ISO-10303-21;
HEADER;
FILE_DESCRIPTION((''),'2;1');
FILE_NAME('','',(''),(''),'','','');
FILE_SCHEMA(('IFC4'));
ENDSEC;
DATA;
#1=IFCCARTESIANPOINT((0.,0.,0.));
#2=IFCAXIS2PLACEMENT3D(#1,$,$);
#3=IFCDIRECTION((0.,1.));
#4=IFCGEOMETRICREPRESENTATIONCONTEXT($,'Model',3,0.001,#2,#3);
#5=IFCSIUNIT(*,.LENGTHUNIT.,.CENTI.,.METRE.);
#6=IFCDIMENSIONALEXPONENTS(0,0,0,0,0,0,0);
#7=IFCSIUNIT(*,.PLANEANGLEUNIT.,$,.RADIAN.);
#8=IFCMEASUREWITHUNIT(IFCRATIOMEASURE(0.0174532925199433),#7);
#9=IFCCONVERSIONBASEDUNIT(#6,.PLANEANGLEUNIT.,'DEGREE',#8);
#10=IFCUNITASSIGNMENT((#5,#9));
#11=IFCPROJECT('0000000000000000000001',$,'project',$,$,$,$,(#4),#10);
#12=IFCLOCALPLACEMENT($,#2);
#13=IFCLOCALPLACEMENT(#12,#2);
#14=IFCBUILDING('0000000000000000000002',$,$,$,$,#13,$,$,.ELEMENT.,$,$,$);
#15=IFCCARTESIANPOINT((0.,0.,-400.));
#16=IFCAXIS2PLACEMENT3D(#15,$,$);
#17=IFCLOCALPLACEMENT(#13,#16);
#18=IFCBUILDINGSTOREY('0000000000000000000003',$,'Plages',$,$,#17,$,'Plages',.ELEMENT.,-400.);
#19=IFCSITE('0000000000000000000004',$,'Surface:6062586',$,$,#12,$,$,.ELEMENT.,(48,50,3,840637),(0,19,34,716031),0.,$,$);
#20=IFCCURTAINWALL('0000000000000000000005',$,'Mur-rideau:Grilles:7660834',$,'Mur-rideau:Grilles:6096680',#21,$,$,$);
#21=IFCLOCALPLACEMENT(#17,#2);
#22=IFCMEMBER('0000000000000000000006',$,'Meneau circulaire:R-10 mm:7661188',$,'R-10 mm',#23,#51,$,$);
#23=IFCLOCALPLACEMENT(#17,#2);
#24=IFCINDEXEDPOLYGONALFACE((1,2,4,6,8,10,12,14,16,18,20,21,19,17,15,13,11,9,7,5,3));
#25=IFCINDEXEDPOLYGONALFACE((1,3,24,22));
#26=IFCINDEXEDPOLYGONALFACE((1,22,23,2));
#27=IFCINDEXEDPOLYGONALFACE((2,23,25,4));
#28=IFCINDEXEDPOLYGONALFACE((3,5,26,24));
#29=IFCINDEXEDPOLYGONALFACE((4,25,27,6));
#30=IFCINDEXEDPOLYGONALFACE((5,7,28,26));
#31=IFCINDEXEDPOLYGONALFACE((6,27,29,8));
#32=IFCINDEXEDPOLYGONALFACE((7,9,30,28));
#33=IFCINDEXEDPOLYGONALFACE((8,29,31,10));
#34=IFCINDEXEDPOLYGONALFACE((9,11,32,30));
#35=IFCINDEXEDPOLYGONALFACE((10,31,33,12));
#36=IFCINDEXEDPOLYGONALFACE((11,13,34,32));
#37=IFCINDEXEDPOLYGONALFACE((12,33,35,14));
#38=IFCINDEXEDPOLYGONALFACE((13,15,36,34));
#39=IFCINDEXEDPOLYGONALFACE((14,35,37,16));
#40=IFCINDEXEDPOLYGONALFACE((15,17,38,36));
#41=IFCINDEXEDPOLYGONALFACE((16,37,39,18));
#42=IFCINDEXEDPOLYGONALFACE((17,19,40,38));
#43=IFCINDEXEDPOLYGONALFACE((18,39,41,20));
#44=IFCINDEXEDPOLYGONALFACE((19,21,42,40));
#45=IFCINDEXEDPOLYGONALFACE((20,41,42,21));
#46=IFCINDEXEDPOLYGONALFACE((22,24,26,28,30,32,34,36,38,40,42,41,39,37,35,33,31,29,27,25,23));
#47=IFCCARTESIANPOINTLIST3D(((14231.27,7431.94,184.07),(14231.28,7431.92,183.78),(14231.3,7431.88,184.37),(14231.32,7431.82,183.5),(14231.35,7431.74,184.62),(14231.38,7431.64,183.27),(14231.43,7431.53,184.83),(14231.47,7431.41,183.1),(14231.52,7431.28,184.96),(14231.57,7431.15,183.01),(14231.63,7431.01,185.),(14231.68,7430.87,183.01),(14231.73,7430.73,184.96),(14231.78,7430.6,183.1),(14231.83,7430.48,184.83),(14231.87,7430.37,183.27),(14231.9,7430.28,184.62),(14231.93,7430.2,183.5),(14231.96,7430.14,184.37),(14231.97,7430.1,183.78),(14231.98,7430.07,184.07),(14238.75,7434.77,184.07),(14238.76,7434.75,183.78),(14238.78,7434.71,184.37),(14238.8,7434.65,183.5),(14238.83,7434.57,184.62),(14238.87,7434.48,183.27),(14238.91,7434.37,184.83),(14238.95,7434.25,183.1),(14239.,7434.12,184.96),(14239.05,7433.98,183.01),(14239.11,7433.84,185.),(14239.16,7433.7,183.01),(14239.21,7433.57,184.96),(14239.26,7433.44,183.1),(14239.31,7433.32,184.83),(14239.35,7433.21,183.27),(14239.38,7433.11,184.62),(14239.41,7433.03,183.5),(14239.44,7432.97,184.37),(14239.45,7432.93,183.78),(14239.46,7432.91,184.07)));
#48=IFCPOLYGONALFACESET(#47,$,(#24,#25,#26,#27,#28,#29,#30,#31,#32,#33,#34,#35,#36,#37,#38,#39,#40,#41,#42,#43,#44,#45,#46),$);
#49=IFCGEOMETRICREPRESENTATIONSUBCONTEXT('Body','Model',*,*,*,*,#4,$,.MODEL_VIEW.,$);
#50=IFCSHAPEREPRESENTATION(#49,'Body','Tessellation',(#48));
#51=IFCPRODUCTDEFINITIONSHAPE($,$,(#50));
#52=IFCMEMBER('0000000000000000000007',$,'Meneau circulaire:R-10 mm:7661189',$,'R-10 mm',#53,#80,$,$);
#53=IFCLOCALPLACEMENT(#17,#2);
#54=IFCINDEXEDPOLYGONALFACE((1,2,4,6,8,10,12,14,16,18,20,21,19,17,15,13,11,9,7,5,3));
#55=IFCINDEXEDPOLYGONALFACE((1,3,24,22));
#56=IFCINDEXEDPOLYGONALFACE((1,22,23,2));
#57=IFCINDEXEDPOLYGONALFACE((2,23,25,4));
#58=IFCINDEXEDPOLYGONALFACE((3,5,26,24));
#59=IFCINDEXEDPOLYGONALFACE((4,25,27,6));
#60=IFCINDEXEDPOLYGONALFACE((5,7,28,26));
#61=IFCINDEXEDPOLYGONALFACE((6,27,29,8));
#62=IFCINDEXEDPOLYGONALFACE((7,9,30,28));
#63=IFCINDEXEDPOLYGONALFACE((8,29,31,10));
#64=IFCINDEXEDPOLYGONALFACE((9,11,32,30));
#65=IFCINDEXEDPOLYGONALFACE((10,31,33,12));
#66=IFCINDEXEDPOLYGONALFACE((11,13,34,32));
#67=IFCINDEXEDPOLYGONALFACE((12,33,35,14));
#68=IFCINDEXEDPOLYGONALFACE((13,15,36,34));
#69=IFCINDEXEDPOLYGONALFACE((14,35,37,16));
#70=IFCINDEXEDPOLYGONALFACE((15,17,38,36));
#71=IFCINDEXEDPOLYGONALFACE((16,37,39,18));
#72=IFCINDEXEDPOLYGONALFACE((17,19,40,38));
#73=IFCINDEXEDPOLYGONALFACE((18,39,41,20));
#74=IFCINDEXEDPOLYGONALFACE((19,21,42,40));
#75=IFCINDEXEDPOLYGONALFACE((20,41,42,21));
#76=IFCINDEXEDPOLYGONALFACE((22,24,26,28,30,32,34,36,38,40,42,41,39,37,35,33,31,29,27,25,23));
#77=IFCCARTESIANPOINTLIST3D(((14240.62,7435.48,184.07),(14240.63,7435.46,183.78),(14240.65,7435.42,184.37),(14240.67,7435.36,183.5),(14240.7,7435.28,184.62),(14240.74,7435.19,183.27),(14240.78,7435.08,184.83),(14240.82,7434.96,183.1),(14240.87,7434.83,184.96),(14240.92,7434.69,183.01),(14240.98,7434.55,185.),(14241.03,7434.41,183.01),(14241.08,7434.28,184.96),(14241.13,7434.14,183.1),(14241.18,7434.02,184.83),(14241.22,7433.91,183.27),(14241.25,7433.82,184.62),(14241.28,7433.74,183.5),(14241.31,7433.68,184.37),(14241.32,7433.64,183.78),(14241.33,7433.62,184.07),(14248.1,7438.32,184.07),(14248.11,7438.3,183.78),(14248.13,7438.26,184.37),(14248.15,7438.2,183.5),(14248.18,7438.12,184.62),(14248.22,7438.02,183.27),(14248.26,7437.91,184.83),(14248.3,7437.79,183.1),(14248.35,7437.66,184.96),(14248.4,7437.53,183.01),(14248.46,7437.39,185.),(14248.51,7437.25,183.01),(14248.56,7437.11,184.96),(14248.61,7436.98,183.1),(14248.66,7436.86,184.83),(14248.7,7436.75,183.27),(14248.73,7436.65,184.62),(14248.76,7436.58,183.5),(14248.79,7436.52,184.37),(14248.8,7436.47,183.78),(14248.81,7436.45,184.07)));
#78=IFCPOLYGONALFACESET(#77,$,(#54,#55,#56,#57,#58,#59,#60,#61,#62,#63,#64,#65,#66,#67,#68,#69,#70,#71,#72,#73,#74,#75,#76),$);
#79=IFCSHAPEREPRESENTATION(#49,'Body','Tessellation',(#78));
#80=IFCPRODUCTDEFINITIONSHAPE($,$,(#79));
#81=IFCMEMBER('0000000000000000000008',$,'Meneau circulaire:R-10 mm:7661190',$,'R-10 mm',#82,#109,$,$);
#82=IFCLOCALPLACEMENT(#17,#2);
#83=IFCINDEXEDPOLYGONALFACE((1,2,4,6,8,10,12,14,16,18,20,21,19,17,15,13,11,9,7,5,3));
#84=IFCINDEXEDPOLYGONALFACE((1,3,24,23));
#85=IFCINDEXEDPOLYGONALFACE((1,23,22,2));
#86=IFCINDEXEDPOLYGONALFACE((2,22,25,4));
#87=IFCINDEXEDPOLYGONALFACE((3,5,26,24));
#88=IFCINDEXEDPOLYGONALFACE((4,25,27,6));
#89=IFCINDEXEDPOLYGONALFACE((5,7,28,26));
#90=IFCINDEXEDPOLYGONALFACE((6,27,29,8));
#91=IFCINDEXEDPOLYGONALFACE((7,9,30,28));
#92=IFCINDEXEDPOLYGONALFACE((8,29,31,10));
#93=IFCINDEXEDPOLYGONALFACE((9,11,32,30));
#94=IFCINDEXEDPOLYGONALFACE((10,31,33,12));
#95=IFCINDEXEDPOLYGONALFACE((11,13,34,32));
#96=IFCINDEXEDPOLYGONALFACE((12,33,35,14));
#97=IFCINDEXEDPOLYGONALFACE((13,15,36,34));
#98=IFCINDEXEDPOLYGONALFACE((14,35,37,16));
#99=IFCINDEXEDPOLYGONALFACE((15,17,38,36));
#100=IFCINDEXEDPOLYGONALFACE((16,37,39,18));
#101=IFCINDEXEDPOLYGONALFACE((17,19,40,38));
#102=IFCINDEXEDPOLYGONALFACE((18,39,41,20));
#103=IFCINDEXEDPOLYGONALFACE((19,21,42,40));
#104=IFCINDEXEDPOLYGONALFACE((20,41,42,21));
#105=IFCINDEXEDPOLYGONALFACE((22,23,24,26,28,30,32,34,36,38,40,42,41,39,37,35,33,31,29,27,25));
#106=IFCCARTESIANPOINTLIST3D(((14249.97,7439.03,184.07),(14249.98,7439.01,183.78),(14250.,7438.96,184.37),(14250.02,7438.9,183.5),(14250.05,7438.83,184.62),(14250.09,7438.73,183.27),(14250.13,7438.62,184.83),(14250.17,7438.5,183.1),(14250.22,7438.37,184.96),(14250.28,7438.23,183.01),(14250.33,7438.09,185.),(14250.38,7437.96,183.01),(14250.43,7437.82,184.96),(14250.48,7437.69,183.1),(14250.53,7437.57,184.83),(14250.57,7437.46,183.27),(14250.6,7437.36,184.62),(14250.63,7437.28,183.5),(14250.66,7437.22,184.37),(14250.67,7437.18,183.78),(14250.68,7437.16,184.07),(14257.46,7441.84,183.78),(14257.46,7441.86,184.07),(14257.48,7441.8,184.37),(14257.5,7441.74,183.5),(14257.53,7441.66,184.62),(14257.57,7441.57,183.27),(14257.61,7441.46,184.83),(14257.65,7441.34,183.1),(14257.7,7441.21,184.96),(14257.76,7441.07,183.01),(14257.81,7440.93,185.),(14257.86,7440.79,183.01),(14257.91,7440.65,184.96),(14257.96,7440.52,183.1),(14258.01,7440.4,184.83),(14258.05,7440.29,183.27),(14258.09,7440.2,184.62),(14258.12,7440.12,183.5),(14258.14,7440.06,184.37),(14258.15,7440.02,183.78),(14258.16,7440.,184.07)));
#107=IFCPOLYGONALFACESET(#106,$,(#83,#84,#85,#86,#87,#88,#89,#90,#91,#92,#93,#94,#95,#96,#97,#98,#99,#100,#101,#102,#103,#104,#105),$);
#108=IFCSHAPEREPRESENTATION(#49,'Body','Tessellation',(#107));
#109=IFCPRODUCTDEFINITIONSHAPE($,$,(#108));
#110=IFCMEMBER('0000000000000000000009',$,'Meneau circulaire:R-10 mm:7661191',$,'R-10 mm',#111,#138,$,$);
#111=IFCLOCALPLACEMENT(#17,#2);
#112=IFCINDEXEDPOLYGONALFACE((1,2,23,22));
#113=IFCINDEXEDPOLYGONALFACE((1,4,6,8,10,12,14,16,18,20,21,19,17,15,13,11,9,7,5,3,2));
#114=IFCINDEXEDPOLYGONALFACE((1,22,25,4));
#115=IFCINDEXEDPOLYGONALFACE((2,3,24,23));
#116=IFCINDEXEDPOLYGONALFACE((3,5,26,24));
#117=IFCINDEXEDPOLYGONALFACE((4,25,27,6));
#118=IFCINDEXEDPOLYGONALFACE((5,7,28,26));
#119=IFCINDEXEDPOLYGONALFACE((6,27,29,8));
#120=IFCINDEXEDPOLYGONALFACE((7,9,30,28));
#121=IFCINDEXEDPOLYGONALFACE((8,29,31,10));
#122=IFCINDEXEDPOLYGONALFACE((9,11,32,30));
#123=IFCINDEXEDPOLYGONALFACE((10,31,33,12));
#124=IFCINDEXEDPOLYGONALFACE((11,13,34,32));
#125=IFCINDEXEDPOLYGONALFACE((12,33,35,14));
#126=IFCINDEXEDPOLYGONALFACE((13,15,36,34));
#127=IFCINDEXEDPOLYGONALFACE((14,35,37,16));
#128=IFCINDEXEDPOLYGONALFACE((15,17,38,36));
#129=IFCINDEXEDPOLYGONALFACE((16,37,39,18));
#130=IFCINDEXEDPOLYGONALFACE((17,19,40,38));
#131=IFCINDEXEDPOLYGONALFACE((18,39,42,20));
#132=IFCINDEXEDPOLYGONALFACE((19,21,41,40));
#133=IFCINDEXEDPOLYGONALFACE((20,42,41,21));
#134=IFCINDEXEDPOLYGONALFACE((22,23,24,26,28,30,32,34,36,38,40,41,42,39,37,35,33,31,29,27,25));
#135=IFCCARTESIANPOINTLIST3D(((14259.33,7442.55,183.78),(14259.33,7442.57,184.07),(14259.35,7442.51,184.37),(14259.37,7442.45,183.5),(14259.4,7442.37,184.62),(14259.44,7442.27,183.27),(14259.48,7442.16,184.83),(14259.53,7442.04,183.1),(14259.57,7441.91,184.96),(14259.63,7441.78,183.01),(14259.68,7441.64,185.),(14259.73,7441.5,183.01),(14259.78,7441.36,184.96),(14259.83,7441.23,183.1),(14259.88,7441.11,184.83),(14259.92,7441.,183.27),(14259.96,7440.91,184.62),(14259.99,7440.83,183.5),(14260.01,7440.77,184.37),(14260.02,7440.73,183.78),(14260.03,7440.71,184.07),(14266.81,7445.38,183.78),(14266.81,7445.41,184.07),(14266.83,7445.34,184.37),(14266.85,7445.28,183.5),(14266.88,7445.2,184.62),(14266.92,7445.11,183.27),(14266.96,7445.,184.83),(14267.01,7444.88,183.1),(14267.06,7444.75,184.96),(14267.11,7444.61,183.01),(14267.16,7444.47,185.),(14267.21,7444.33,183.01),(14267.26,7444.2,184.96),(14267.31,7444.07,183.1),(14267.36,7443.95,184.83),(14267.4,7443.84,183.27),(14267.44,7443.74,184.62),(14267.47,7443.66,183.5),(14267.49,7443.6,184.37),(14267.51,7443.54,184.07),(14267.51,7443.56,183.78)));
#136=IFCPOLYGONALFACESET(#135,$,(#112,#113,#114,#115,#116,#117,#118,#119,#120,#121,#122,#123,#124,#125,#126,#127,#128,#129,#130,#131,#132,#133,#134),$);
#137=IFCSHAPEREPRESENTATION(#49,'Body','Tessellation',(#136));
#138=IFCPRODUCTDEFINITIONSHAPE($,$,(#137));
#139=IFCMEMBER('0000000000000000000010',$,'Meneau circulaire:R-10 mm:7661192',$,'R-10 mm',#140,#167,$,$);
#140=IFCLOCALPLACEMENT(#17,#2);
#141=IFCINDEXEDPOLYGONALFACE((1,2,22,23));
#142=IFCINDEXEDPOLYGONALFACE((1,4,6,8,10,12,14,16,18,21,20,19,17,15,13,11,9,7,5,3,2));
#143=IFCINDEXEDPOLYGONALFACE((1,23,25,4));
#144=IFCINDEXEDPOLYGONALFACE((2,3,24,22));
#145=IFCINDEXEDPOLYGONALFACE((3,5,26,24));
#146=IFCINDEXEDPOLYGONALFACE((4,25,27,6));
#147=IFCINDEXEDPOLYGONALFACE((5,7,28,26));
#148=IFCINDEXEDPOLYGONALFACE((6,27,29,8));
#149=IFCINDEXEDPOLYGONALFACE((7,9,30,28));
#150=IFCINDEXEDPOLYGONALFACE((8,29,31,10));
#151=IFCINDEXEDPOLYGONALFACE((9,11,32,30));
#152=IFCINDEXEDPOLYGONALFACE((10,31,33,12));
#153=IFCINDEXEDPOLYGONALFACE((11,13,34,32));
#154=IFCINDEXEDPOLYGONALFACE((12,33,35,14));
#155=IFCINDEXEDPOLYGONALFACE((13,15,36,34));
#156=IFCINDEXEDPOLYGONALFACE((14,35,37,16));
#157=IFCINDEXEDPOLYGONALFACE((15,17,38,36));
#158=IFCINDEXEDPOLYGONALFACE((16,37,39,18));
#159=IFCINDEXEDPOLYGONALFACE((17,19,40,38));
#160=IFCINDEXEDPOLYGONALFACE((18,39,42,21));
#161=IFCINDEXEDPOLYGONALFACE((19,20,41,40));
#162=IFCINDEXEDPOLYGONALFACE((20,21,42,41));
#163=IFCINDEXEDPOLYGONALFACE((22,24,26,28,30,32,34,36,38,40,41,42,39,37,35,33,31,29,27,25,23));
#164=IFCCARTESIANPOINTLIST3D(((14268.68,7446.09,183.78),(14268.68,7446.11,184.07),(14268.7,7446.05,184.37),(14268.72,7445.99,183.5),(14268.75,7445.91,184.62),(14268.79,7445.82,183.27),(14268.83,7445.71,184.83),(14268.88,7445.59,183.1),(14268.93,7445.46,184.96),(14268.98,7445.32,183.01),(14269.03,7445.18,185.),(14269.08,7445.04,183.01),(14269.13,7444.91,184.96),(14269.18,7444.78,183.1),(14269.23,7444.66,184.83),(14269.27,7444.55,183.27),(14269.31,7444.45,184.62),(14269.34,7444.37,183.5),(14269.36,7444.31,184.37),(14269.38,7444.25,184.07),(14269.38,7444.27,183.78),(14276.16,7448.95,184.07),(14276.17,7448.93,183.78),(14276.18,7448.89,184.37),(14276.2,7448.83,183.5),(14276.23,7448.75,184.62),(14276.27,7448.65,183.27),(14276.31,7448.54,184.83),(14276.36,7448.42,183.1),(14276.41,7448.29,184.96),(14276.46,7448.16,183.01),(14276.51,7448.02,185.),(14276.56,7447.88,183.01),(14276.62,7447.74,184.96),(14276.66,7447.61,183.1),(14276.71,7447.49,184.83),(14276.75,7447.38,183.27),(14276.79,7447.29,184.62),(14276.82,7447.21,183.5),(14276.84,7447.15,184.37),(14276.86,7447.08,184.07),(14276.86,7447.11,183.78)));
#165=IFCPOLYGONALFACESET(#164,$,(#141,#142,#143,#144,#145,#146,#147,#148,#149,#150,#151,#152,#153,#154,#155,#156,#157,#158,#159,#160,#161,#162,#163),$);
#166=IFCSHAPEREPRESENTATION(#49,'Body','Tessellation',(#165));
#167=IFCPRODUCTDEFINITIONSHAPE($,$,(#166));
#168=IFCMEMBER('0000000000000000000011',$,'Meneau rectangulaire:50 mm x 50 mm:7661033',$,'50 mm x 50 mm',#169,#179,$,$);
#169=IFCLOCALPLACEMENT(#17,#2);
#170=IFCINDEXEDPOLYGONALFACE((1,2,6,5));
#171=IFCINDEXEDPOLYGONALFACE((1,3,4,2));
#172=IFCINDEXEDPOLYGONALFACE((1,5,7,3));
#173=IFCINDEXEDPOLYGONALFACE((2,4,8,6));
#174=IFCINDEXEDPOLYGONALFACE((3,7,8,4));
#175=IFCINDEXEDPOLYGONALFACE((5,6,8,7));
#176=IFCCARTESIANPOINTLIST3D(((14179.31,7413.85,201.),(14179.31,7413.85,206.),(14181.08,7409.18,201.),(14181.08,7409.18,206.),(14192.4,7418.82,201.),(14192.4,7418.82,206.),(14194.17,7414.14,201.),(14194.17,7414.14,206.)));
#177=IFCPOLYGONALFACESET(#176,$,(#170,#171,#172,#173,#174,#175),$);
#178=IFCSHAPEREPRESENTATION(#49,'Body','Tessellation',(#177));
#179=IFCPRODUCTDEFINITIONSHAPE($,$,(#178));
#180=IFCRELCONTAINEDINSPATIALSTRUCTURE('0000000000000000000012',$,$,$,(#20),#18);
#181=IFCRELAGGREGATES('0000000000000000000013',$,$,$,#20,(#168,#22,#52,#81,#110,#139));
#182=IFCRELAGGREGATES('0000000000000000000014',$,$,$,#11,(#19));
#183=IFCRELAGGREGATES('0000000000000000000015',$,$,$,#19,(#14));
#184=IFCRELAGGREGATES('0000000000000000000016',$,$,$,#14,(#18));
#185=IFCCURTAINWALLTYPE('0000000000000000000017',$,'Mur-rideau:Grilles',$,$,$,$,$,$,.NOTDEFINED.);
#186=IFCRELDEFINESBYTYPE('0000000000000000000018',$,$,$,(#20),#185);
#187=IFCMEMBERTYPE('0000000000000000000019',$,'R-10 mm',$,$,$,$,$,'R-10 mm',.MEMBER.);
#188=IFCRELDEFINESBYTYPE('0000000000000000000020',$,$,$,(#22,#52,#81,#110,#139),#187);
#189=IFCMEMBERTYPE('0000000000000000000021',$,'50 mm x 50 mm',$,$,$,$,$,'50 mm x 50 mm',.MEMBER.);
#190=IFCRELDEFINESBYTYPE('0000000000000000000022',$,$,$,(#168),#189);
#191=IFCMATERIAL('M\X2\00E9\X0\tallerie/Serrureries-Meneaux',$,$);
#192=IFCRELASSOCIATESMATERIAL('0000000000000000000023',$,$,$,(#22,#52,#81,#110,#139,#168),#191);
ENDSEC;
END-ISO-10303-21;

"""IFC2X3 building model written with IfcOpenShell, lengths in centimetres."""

from ifc_helpers import new_model, entity, si_unit, converted_unit, direction, frame, frame_2d, origin, origin_2d_with_axis, place, context, subcontext, project, spatial, rectangle, circle, extrude, source, transform, mapped, material, type_object, type_shapes, element, aggregate, save


model = new_model("IFC2X3")

# Units and contexts
model_context = context("Model", 3, precision=0.001, world=origin(), true_north=direction((0.0, 1.0)))
body_context = subcontext(model_context, "Body", "Model", "MODEL_VIEW")
ifc_project = project(units=[si_unit("LENGTHUNIT", "METRE", prefix="CENTI"), converted_unit("PLANEANGLEUNIT", "DEGREE", entity("IfcRatioMeasure", 0.0174532925199433), si_unit("PLANEANGLEUNIT", "RADIAN"), dimensions=[0, 0, 0, 0, 0, 0, 0])], contexts=[model_context])

# Site, building, storey
site_placement = place(None, origin())
site = spatial("IfcSite", under=ifc_project, at=site_placement, Name="Surface:6062586", CompositionType="ELEMENT", RefLatitude=(48, 50, 3, 840637), RefLongitude=(0, 19, 34, 716031), RefElevation=0.0)
building_placement = place(site_placement, origin())
building = spatial("IfcBuilding", under=site, at=building_placement, CompositionType="ELEMENT")
storey_placement = place(building_placement, frame((0.0, 0.0, -400.0)))
storey = spatial("IfcBuildingStorey", under=building, at=storey_placement, Name="Plages", LongName="Plages", CompositionType="ELEMENT", Elevation=-400.0)

# Curtain wall, members
curtain_wall_type = type_object("IfcCurtainWallType", Name="Mur-rideau:Grilles", PredefinedType="NOTDEFINED")
curtain_wall_placement = place(storey_placement, frame((0.0, 0.0, 400.0)))
curtain_wall = element("IfcCurtainWall", 1, at=curtain_wall_placement, inside=storey, type_object=curtain_wall_type, Name="Mur-rideau:Grilles:7660834", ObjectType="Mur-rideau:Grilles:6096680")
ifc_material = material(Name="Métallerie/Serrureries-Meneaux")
member_type_1 = type_object("IfcMemberType", Name="R-10 mm", ElementType="R-10 mm", PredefinedType="MEMBER")
shared_shape_1 = source(origin(), body_context, "Body", "SweptSolid", [
    extrude(circle(Radius=1.0, at=frame_2d((0.0, 0.0), x_axis=(1.0, 0.0))), frame((0.0, 0.0, -8.0)), (0.0, 0.0, 1.0), 8.0),
])
type_shapes(member_type_1, [shared_shape_1])
member_1_placement = place(storey_placement, frame((14239.11, 7433.84, 184.0), z_axis=(0.935103, 0.354376, 0.0), x_axis=(0.0, 0.0, 1.0)))
member_1 = element("IfcMember", 2, at=member_1_placement, type_object=member_type_1, material=ifc_material, Name="Meneau circulaire:R-10 mm:7661188", ObjectType="R-10 mm", context=body_context, shape_type="MappedRepresentation", body=[
    mapped(shared_shape_1, transform((0.0, 0.0, 0.0), scale=1.0)),
])
member_2_placement = place(storey_placement, frame((14248.46, 7437.39, 184.0), z_axis=(0.935103, 0.354376, 0.0), x_axis=(0.0, 0.0, 1.0)))
member_2 = element("IfcMember", 3, at=member_2_placement, type_object=member_type_1, material=ifc_material, Name="Meneau circulaire:R-10 mm:7661189", ObjectType="R-10 mm", context=body_context, shape_type="MappedRepresentation", body=[
    mapped(shared_shape_1, transform((0.0, 0.0, 0.0), scale=1.0)),
])
member_3_placement = place(storey_placement, frame((14257.81, 7440.93, 184.0), z_axis=(0.935103, 0.354376, 0.0), x_axis=(0.0, 0.0, 1.0)))
member_3 = element("IfcMember", 4, at=member_3_placement, type_object=member_type_1, material=ifc_material, Name="Meneau circulaire:R-10 mm:7661190", ObjectType="R-10 mm", context=body_context, shape_type="MappedRepresentation", body=[
    mapped(shared_shape_1, transform((0.0, 0.0, 0.0), scale=1.0)),
])
member_4_placement = place(storey_placement, frame((14267.16, 7444.47, 184.0), z_axis=(0.935103, 0.354376, 0.0), x_axis=(0.0, 0.0, 1.0)))
member_4 = element("IfcMember", 5, at=member_4_placement, type_object=member_type_1, material=ifc_material, Name="Meneau circulaire:R-10 mm:7661191", ObjectType="R-10 mm", context=body_context, shape_type="MappedRepresentation", body=[
    mapped(shared_shape_1, transform((0.0, 0.0, 0.0), scale=1.0)),
])
member_5_placement = place(storey_placement, frame((14276.51, 7448.02, 184.0), z_axis=(0.935103, 0.354376, 0.0), x_axis=(0.0, 0.0, 1.0)))
member_5 = element("IfcMember", 6, at=member_5_placement, type_object=member_type_1, material=ifc_material, Name="Meneau circulaire:R-10 mm:7661192", ObjectType="R-10 mm", context=body_context, shape_type="MappedRepresentation", body=[
    mapped(shared_shape_1, transform((0.0, 0.0, 0.0), scale=1.0)),
])
member_type_2 = type_object("IfcMemberType", Name="50 mm x 50 mm", ElementType="50 mm x 50 mm", PredefinedType="MEMBER")
shared_shape_2 = source(origin(), body_context, "Body", "SweptSolid", [
    extrude(rectangle(XDim=5.0, YDim=5.0, at=origin_2d_with_axis()), frame((-2.5, 0.0, -14.0), z_axis=(0.0, 0.0, 1.0), x_axis=(0.0, -1.0, 0.0)), (0.0, 0.0, 1.0), 14.0),
])
type_shapes(member_type_2, [shared_shape_2])
member_6_placement = place(storey_placement, frame((14193.29, 7416.48, 206.0), z_axis=(0.935103, 0.354376, 0.0), x_axis=(0.0, 0.0, 1.0)))
member_6 = element("IfcMember", 7, at=member_6_placement, type_object=member_type_2, material=ifc_material, Name="Meneau rectangulaire:50 mm x 50 mm:7661033", ObjectType="50 mm x 50 mm", context=body_context, shape_type="MappedRepresentation", body=[
    mapped(shared_shape_2, transform((0.0, 0.0, 0.0), scale=1.0)),
])
aggregate(curtain_wall, [member_6, member_1, member_2, member_3, member_4, member_5])

save(model, "model.ifc")
